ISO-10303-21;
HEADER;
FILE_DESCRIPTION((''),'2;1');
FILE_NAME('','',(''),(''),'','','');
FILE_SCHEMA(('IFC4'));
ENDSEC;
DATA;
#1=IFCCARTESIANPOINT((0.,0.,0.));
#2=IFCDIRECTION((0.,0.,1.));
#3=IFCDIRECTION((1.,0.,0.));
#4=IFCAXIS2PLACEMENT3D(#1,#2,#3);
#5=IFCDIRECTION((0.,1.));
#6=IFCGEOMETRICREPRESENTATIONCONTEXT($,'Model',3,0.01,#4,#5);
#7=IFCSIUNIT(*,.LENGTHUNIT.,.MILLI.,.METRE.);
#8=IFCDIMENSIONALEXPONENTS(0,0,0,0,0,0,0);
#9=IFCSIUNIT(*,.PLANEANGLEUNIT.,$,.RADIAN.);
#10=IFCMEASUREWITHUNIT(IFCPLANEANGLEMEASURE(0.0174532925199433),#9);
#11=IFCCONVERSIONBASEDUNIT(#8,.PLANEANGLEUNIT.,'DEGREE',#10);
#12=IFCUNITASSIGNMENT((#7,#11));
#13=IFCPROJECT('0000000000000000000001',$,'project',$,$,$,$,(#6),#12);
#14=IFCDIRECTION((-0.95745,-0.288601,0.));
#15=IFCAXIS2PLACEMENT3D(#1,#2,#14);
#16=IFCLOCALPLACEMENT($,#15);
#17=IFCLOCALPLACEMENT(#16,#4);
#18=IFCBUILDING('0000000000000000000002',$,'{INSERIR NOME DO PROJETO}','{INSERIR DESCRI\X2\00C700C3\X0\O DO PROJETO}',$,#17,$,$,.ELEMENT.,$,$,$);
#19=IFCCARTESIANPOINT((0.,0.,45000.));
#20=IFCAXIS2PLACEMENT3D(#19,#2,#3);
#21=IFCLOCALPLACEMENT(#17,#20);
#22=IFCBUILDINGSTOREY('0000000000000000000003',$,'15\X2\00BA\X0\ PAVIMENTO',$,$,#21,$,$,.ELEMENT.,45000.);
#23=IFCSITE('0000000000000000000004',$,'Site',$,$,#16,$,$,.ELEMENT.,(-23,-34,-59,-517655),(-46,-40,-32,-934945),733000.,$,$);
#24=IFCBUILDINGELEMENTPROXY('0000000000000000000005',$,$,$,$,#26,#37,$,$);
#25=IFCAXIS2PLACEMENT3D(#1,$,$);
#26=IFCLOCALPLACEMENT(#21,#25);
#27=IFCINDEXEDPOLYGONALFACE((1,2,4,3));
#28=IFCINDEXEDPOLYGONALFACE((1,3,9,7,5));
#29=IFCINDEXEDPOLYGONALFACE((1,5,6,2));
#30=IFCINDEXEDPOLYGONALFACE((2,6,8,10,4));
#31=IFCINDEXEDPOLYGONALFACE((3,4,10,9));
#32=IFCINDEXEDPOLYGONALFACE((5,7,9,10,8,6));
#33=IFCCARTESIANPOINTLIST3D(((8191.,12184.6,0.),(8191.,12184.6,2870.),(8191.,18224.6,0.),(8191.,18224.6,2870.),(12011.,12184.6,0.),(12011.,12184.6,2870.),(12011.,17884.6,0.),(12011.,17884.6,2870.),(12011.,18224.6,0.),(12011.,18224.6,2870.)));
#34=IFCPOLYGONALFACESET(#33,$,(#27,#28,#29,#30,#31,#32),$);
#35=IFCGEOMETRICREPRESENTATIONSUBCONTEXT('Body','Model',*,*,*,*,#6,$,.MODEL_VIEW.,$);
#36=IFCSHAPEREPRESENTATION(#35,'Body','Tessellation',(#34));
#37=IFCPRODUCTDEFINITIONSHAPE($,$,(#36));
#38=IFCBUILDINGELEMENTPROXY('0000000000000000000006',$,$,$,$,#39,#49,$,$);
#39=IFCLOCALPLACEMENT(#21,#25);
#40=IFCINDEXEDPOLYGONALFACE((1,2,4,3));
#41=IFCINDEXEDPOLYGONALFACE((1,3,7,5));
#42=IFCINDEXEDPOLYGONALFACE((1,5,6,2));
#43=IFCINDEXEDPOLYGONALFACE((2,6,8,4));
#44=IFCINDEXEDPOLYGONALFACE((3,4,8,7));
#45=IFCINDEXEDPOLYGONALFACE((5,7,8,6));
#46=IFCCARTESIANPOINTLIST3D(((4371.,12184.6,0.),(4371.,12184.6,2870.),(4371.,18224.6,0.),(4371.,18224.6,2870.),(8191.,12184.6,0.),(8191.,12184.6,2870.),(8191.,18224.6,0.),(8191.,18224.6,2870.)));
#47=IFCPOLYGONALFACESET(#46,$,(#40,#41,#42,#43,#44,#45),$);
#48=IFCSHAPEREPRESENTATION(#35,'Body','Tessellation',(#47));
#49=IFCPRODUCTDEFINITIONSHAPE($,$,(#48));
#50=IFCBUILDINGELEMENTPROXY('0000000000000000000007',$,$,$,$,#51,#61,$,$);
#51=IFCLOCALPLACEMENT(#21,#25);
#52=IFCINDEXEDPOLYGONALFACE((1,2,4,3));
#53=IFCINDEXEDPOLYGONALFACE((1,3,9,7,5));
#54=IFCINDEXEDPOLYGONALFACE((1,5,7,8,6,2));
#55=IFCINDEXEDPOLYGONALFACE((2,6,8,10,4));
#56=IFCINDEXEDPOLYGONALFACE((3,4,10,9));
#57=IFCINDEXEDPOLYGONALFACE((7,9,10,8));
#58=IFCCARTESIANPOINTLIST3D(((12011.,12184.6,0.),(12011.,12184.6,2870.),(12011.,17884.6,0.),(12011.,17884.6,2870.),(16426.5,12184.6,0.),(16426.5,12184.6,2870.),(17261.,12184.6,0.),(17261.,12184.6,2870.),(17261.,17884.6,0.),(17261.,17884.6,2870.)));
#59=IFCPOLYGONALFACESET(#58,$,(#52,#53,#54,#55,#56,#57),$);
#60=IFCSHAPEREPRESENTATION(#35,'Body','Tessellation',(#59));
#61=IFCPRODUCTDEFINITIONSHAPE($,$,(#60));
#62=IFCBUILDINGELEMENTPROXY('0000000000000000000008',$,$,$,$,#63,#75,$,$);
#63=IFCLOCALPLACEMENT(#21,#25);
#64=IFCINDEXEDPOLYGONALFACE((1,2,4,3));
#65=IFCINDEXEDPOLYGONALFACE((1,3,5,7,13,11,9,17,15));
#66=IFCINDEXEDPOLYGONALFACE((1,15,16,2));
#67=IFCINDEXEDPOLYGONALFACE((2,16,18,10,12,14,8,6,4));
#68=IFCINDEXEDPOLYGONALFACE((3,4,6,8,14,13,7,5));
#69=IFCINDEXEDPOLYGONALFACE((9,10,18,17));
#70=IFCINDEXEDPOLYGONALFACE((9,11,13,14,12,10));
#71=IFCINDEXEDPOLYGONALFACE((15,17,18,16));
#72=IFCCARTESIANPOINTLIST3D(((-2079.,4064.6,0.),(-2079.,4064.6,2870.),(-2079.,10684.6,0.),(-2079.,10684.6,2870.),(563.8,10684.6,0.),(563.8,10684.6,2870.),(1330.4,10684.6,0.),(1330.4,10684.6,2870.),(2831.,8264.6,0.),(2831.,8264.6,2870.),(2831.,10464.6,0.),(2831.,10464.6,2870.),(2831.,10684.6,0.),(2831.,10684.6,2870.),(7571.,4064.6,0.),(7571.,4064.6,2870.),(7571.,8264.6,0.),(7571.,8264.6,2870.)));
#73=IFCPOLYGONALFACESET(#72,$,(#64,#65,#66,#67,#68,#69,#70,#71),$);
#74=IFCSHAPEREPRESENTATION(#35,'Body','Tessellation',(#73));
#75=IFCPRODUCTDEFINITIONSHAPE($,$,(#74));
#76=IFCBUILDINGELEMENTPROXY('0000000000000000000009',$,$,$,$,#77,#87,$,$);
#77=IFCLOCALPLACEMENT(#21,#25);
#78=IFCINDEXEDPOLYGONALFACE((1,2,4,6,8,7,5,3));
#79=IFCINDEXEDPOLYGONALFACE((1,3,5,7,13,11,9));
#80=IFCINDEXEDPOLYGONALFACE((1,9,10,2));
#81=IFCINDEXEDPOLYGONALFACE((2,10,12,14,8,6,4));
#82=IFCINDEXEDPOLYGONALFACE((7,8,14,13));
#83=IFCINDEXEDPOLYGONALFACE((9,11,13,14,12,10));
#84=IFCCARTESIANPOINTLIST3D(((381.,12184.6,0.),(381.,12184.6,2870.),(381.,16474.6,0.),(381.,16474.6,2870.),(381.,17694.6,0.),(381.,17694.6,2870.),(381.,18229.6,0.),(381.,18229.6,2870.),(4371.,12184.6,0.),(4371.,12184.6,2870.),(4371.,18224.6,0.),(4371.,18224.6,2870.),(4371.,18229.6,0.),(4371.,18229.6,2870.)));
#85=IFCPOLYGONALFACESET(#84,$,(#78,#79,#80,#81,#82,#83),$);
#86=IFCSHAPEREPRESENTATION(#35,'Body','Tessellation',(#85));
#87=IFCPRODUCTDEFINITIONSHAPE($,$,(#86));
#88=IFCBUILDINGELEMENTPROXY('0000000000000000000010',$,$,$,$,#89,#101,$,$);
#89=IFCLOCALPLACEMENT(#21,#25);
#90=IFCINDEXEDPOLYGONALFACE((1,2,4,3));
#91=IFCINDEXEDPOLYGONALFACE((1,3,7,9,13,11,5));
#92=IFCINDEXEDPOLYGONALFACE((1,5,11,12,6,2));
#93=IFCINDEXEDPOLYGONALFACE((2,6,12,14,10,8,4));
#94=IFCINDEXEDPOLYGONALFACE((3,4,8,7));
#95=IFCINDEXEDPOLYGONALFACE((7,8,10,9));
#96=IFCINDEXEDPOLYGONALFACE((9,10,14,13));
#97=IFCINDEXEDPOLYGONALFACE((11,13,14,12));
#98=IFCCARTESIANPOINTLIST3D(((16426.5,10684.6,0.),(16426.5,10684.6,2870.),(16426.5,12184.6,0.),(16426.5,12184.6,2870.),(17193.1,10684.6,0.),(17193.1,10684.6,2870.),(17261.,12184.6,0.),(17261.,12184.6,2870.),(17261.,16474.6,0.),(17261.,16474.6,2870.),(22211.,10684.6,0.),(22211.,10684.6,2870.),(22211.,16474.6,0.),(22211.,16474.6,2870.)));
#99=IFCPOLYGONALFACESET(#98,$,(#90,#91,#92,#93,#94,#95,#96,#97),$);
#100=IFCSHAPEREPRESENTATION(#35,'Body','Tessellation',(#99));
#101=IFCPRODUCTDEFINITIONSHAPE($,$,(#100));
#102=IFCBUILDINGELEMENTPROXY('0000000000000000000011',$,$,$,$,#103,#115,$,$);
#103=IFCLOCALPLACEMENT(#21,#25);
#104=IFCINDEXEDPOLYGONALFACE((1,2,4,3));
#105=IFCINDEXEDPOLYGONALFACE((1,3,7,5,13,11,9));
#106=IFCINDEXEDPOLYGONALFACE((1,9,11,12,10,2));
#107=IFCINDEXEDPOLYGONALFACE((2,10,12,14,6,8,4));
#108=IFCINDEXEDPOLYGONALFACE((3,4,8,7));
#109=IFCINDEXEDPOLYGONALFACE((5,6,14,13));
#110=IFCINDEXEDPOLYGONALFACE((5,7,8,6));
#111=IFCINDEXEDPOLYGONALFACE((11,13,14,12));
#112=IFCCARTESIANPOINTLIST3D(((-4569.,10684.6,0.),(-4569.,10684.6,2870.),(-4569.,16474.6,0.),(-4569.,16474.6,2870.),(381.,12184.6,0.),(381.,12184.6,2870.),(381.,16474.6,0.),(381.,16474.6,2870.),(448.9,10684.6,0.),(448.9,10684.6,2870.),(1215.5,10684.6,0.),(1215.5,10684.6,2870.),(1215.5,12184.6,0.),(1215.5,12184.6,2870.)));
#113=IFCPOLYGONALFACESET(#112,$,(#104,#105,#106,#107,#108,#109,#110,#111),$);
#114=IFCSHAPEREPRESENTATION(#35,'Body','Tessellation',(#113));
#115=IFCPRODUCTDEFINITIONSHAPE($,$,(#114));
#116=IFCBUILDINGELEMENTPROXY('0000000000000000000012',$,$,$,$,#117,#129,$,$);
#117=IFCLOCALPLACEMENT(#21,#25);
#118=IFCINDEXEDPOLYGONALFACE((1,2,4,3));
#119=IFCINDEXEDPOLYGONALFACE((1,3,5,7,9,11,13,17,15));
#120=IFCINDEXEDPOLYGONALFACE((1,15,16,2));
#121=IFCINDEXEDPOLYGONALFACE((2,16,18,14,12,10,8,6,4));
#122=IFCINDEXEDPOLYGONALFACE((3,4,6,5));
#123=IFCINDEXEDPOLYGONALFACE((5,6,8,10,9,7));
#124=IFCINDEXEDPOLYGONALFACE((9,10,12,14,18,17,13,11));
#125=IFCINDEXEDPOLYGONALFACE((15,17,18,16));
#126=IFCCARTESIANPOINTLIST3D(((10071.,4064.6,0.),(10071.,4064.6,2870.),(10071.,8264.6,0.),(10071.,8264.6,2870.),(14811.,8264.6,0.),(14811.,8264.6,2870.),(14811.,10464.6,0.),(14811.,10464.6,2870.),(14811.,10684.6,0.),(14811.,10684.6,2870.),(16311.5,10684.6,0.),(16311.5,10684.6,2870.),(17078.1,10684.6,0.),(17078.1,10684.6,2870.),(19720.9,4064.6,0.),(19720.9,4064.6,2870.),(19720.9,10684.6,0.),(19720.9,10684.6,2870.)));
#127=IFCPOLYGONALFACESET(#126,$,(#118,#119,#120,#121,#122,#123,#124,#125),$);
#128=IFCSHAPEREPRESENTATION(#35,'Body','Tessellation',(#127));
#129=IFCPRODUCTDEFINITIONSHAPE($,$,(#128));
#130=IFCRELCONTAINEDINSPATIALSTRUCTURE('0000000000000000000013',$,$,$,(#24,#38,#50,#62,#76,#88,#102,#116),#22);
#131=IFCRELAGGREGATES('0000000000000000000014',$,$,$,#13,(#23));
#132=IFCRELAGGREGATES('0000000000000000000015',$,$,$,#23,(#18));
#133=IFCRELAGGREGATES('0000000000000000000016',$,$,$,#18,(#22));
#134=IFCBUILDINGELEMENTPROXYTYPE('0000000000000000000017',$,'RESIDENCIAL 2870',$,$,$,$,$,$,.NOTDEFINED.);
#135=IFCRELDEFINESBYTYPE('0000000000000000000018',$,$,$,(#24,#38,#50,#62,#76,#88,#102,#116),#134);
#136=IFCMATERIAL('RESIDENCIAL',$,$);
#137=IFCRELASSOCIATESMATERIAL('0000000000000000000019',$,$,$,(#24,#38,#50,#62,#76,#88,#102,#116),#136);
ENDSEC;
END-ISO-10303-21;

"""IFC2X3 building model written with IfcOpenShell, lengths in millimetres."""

from ifc_helpers import new_model, entity, si_unit, converted_unit, direction, frame, origin_with_axes, place, context, subcontext, project, spatial, polyline, outline, extrude, material, type_object, element, save


model = new_model("IFC2X3")

# Units and contexts
model_context = context("Model", 3, precision=0.01, world=origin_with_axes(), true_north=direction((0.0, 1.0)))
body_context = subcontext(model_context, "Body", "Model", "MODEL_VIEW")
ifc_project = project(units=[si_unit("LENGTHUNIT", "METRE", prefix="MILLI"), converted_unit("PLANEANGLEUNIT", "DEGREE", entity("IfcPlaneAngleMeasure", 0.0174532925199433), si_unit("PLANEANGLEUNIT", "RADIAN"), dimensions=[0, 0, 0, 0, 0, 0, 0])], contexts=[model_context])

# Site, building, storey
site_placement = place(None, frame((0.0, 0.0, 0.0), z_axis=(0.0, 0.0, 1.0), x_axis=(-0.95745, -0.288601, 0.0)))
site = spatial("IfcSite", under=ifc_project, at=site_placement, Name="Site", CompositionType="ELEMENT", RefLatitude=(-23, -34, -59, -517655), RefLongitude=(-46, -40, -32, -934945), RefElevation=733000.0)
building_placement = place(site_placement, origin_with_axes())
building = spatial("IfcBuilding", under=site, at=building_placement, Name="{INSERIR NOME DO PROJETO}", Description="{INSERIR DESCRIÇÃO DO PROJETO}", CompositionType="ELEMENT")
storey_placement = place(building_placement, frame((0.0, 0.0, 45000.0), z_axis=(0.0, 0.0, 1.0), x_axis=(1.0, 0.0, 0.0)))
storey = spatial("IfcBuildingStorey", under=building, at=storey_placement, Name="15º PAVIMENTO", CompositionType="ELEMENT", Elevation=45000.0)

# Building element proxies
ifc_material_1 = material(Name="RESIDENCIAL")
building_element_proxy_type_1 = type_object("IfcBuildingElementProxyType", Name="RESIDENCIAL 2870", PredefinedType="NOTDEFINED")
proxy_1_placement = place(storey_placement, frame((8191.0, 18224.6, 0.0), z_axis=(0.0, 0.0, 1.0), x_axis=(1.0, 0.0, 0.0)))
element("IfcBuildingElementProxy", 1, at=proxy_1_placement, inside=storey, type_object=building_element_proxy_type_1, material=ifc_material_1, context=body_context, shape_type="SweptSolid", body=[
    extrude(outline(polyline([(0.0, 0.0), (0.0, -6040.0), (3820.0, -6040.0), (3820.0, -340.0), (3820.0, 0.0), (0.0, 0.0)])), origin_with_axes(), (0.0, 0.0, 1.0), 2870.0),
])
proxy_2_placement = place(storey_placement, frame((4371.0, 18224.6, 0.0), z_axis=(0.0, 0.0, 1.0), x_axis=(1.0, 0.0, 0.0)))
element("IfcBuildingElementProxy", 2, at=proxy_2_placement, inside=storey, type_object=building_element_proxy_type_1, material=ifc_material_1, context=body_context, shape_type="SweptSolid", body=[
    extrude(outline(polyline([(0.0, 0.0), (0.0, -6040.0), (3820.0, -6040.0), (3820.0, 0.0), (0.0, 0.0)])), origin_with_axes(), (0.0, 0.0, 1.0), 2870.0),
])
proxy_3_placement = place(storey_placement, frame((12011.0, 12184.6, 0.0), z_axis=(0.0, 0.0, 1.0), x_axis=(1.0, 0.0, 0.0)))
element("IfcBuildingElementProxy", 3, at=proxy_3_placement, inside=storey, type_object=building_element_proxy_type_1, material=ifc_material_1, context=body_context, shape_type="SweptSolid", body=[
    extrude(outline(polyline([(0.0, 0.0), (4415.5, 0.0), (5250.0, 0.0), (5250.0, 5700.0), (0.0, 5700.0), (0.0, 0.0)])), origin_with_axes(), (0.0, 0.0, 1.0), 2870.0),
])
proxy_4_placement = place(storey_placement, frame((-2079.0, 4064.6, 0.0), z_axis=(0.0, 0.0, 1.0), x_axis=(1.0, 0.0, 0.0)))
element("IfcBuildingElementProxy", 4, at=proxy_4_placement, inside=storey, type_object=building_element_proxy_type_1, material=ifc_material_1, context=body_context, shape_type="SweptSolid", body=[
    extrude(outline(polyline([(0.0, 0.0), (9650.0, 0.0), (9650.0, 4200.0), (4910.0, 4200.0), (4910.0, 6400.0), (4910.0, 6620.0), (3409.4, 6620.0), (2642.8, 6620.0), (0.0, 6620.0), (0.0, 0.0)])), origin_with_axes(), (0.0, 0.0, 1.0), 2870.0),
])
proxy_5_placement = place(storey_placement, frame((381.0, 16474.6, 0.0), z_axis=(0.0, 0.0, 1.0), x_axis=(1.0, 0.0, 0.0)))
element("IfcBuildingElementProxy", 5, at=proxy_5_placement, inside=storey, type_object=building_element_proxy_type_1, material=ifc_material_1, context=body_context, shape_type="SweptSolid", body=[
    extrude(outline(polyline([(0.0, 0.0), (0.0, -4290.0), (3990.0, -4290.0), (3990.0, 1750.0), (3990.0, 1755.0), (0.0, 1755.0), (0.0, 1220.0), (0.0, 0.0)])), origin_with_axes(), (0.0, 0.0, 1.0), 2870.0),
])
proxy_6_placement = place(storey_placement, frame((17261.0, 12184.6, 0.0), z_axis=(0.0, 0.0, 1.0), x_axis=(1.0, 0.0, 0.0)))
element("IfcBuildingElementProxy", 6, at=proxy_6_placement, inside=storey, type_object=building_element_proxy_type_1, material=ifc_material_1, context=body_context, shape_type="SweptSolid", body=[
    extrude(outline(polyline([(0.0, 0.0), (-834.5, 0.0), (-834.5, -1500.0), (-67.9, -1500.0), (4950.0, -1500.0), (4950.0, 4290.0), (0.0, 4290.0), (0.0, 0.0)])), origin_with_axes(), (0.0, 0.0, 1.0), 2870.0),
])
proxy_7_placement = place(storey_placement, frame((-4569.0, 16474.6, 0.0), z_axis=(0.0, 0.0, 1.0), x_axis=(1.0, 0.0, 0.0)))
element("IfcBuildingElementProxy", 7, at=proxy_7_placement, inside=storey, type_object=building_element_proxy_type_1, material=ifc_material_1, context=body_context, shape_type="SweptSolid", body=[
    extrude(outline(polyline([(0.0, 0.0), (0.0, -5790.0), (5017.9, -5790.0), (5784.5, -5790.0), (5784.5, -4290.0), (4950.0, -4290.0), (4950.0, 0.0), (0.0, 0.0)])), origin_with_axes(), (0.0, 0.0, 1.0), 2870.0),
])
proxy_8_placement = place(storey_placement, frame((19720.9, 4064.6, 0.0), z_axis=(0.0, 0.0, 1.0), x_axis=(1.0, 0.0, 0.0)))
element("IfcBuildingElementProxy", 8, at=proxy_8_placement, inside=storey, type_object=building_element_proxy_type_1, material=ifc_material_1, context=body_context, shape_type="SweptSolid", body=[
    extrude(outline(polyline([(0.0, 0.0), (0.0, 6620.0), (-2642.8, 6620.0), (-3409.4, 6620.0), (-4910.0, 6620.0), (-4910.0, 6400.0), (-4910.0, 4200.0), (-9650.0, 4200.0), (-9650.0, 0.0), (0.0, 0.0)])), origin_with_axes(), (0.0, 0.0, 1.0), 2870.0),
])

save(model, "model.ifc")
